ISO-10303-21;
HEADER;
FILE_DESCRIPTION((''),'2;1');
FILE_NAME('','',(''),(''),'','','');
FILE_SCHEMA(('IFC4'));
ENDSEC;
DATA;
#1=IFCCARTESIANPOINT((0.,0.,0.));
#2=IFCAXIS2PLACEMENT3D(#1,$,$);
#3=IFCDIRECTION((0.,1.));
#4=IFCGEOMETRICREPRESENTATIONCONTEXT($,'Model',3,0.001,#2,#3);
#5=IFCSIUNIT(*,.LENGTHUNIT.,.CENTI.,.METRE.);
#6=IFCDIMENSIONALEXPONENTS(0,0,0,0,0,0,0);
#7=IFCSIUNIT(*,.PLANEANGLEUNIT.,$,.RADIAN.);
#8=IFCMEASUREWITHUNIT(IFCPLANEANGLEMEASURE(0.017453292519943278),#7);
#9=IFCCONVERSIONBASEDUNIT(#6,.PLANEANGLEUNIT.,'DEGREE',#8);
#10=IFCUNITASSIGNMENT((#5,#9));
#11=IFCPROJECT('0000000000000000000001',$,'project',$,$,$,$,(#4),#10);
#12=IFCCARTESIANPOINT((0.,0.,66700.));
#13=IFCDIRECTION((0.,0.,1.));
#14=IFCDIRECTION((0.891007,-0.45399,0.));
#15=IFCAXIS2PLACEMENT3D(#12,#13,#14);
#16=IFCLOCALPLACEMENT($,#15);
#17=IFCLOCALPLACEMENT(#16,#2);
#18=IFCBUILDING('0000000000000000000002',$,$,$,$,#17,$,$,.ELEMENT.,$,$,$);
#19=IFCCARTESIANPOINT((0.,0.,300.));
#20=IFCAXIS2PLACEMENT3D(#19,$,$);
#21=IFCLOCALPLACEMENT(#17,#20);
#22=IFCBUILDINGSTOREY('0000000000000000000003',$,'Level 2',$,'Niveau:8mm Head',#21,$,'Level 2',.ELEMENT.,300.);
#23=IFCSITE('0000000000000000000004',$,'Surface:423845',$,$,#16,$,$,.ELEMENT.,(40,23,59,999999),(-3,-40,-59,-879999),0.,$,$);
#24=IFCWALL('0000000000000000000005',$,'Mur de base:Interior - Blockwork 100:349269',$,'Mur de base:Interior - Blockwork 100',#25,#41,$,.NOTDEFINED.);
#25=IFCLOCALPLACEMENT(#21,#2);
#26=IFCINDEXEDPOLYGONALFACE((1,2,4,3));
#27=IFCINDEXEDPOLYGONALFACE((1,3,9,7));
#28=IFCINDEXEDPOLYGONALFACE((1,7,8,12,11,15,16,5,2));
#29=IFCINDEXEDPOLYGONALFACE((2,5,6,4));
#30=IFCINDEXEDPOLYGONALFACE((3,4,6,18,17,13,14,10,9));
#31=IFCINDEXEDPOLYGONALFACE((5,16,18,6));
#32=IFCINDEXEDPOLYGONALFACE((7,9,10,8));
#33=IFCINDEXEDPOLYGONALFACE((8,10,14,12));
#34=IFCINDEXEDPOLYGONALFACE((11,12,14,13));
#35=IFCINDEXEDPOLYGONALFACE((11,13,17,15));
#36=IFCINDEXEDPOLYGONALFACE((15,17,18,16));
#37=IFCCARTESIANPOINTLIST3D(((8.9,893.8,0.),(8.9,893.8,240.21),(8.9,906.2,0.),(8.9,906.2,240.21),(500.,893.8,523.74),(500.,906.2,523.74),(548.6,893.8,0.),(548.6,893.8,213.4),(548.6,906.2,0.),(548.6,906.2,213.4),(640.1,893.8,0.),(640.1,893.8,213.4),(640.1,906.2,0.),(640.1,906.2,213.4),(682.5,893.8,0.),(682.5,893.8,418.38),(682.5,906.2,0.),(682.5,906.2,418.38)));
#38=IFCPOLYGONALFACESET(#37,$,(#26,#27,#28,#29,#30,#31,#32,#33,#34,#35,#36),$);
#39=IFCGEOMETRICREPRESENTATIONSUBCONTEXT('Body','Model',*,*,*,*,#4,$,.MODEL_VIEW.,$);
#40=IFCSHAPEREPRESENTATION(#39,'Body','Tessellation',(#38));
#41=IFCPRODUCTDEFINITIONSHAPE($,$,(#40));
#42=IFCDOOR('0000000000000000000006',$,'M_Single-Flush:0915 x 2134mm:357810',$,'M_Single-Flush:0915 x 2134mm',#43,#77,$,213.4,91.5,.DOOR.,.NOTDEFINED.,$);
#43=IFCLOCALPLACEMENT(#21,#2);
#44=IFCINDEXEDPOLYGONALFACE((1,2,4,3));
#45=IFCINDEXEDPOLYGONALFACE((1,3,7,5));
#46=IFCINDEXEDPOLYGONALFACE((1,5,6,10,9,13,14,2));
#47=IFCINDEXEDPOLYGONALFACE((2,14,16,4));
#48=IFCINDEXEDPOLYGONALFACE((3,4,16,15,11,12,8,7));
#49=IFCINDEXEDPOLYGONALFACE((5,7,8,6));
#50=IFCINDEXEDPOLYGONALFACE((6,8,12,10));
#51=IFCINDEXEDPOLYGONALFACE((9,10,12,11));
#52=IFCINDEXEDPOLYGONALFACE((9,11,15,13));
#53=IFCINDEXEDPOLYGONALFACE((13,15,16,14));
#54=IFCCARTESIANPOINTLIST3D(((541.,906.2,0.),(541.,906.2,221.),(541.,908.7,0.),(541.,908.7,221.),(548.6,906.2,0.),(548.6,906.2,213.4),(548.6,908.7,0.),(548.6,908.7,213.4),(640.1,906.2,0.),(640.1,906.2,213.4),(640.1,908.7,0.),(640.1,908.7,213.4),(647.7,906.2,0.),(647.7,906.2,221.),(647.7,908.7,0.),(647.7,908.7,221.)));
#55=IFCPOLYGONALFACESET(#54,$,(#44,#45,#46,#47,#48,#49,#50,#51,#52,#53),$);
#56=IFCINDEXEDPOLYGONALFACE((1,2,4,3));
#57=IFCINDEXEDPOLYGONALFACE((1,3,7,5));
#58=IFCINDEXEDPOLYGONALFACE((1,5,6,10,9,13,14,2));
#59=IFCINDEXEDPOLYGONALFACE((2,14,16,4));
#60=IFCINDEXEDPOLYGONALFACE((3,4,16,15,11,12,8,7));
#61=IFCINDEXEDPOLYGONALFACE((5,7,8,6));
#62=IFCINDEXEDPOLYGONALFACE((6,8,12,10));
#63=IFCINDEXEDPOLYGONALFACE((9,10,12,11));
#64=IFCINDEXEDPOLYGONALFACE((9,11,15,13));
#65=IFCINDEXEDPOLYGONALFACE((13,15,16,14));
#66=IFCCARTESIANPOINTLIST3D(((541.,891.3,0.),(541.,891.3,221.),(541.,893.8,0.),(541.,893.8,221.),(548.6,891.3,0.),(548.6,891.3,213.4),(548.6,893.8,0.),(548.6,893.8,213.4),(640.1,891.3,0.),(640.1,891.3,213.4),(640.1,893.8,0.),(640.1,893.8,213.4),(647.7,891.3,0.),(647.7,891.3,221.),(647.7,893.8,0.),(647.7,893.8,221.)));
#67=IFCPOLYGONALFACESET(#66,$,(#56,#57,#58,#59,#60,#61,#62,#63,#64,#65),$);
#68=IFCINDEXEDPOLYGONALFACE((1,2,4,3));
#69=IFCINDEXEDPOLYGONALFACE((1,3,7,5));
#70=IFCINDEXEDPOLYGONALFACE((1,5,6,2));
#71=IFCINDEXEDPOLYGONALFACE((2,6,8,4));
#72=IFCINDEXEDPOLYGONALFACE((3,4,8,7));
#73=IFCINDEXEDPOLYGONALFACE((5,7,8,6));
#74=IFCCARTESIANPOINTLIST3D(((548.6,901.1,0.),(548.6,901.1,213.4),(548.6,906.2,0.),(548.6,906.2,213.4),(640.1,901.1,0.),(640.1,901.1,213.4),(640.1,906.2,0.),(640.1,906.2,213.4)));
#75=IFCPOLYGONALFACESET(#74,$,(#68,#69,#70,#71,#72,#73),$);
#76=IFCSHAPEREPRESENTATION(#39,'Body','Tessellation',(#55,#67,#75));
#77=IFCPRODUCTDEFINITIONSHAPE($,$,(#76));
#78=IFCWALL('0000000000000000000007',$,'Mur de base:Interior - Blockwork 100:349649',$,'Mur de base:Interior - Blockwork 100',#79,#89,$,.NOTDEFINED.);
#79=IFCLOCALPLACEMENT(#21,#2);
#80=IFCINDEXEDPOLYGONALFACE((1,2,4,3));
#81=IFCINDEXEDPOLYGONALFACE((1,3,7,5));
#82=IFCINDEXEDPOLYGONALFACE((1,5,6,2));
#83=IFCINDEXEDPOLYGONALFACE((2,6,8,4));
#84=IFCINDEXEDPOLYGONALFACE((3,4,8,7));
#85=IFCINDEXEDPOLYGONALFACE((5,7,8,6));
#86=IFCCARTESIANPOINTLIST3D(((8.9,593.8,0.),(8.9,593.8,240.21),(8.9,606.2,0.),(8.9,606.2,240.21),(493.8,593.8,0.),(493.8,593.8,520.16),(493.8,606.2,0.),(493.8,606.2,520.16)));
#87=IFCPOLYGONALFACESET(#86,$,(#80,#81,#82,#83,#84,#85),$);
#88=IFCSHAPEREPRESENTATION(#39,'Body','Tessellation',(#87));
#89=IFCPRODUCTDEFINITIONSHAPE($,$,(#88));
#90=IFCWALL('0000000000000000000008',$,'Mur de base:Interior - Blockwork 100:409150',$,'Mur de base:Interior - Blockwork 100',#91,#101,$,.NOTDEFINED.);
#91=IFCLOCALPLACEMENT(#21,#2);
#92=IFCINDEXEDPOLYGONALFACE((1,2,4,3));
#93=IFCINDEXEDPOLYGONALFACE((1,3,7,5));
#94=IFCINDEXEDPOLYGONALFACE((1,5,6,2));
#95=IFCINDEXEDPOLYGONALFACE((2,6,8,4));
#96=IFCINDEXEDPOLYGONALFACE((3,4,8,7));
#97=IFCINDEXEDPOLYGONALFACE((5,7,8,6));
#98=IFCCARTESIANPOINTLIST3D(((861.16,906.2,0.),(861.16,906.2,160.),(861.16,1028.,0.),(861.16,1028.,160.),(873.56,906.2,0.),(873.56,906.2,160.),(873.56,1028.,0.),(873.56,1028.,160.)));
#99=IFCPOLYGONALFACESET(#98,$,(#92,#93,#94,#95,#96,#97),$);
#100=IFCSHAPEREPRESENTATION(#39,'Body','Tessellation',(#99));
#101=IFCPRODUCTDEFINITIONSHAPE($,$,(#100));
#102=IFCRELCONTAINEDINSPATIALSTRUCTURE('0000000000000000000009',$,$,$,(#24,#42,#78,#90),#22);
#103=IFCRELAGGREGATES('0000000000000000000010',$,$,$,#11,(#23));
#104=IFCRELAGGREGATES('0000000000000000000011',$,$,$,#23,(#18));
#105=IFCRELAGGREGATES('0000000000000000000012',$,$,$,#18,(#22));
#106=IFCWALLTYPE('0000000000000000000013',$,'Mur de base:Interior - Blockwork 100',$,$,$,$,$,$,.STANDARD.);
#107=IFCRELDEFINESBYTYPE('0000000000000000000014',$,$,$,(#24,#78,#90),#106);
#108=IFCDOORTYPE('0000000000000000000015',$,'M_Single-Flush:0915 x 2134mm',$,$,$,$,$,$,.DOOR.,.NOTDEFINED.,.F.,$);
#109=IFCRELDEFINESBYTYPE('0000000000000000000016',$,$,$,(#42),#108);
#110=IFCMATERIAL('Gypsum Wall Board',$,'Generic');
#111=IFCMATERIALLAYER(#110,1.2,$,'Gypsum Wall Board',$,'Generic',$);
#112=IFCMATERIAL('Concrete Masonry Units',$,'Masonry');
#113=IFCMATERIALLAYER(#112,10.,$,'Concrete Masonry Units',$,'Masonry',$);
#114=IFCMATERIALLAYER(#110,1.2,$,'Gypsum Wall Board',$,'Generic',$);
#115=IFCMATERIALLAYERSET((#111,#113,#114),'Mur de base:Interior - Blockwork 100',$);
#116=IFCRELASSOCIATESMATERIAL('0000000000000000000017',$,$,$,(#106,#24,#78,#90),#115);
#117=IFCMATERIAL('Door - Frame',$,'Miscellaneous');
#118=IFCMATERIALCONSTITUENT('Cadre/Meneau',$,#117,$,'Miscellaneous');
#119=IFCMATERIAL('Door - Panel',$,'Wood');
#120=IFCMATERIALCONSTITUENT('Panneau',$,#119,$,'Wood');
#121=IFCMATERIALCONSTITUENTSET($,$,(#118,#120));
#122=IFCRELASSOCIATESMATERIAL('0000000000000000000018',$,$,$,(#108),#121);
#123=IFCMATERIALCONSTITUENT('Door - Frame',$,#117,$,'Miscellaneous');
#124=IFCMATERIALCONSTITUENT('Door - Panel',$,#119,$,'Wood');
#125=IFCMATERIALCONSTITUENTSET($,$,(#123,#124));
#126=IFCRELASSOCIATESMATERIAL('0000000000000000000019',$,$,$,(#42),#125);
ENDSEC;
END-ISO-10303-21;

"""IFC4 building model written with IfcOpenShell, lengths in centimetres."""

from ifc_helpers import new_model, entity, si_unit, converted_unit, direction, frame, frame_2d, origin, origin_2d_with_axis, place, context, subcontext, project, spatial, polyline, rectangle, outline, extrude, clip, bounded_halfspace, source, transform, mapped, material, layer, layer_set, layer_usage, constituent, constituent_set, type_object, type_shapes, element, fill, save


model = new_model("IFC4")

# Units and contexts
model_context = context("Model", 3, precision=0.001, world=origin(), true_north=direction((0.0, 1.0)))
body_context = subcontext(model_context, "Body", "Model", "MODEL_VIEW")
ifc_project = project(units=[si_unit("LENGTHUNIT", "METRE", prefix="CENTI"), converted_unit("PLANEANGLEUNIT", "DEGREE", entity("IfcPlaneAngleMeasure", 0.017453292519943278), si_unit("PLANEANGLEUNIT", "RADIAN"), dimensions=[0, 0, 0, 0, 0, 0, 0])], contexts=[model_context])

# Site, building, storey
site_placement = place(None, frame((0.0, 0.0, 66700.0), z_axis=(0.0, 0.0, 1.0), x_axis=(0.891007, -0.45399, 0.0)))
site = spatial("IfcSite", under=ifc_project, at=site_placement, Name="Surface:423845", CompositionType="ELEMENT", RefLatitude=(40, 23, 59, 999999), RefLongitude=(-3, -40, -59, -879999), RefElevation=0.0)
building_placement = place(site_placement, origin())
building = spatial("IfcBuilding", under=site, at=building_placement, CompositionType="ELEMENT")
storey_placement = place(building_placement, frame((0.0, 0.0, 300.0)))
storey = spatial("IfcBuildingStorey", under=building, at=storey_placement, Name="Level 2", ObjectType="Niveau:8mm Head", LongName="Level 2", CompositionType="ELEMENT", Elevation=300.0)

# Shared definitions
ifc_material_1 = material(Name="Gypsum Wall Board", Category="Generic")
ifc_layer_1 = layer(ifc_material_1, 1.2, Name="Gypsum Wall Board", Category="Generic")
ifc_material_2 = material(Name="Concrete Masonry Units", Category="Masonry")
ifc_layer_2 = layer(ifc_material_2, 10.0, Name="Concrete Masonry Units", Category="Masonry")
ifc_layer_3 = layer(ifc_material_1, 1.2, Name="Gypsum Wall Board", Category="Generic")
ifc_layer_set_1 = layer_set([ifc_layer_1, ifc_layer_2, ifc_layer_3], Name="Mur de base:Interior - Blockwork 100")
wall_type = type_object("IfcWallType", Name="Mur de base:Interior - Blockwork 100", PredefinedType="STANDARD", material=ifc_layer_set_1)

# Shared definitions
ifc_material_3 = material(Name="Door - Frame", Category="Miscellaneous")
ifc_material_4 = material(Name="Door - Panel", Category="Wood")

# Wall, opening, door
ifc_layer_usage_1 = layer_usage(ifc_layer_set_1, "AXIS2", "NEGATIVE", 6.2)
wall_1_placement = place(storey_placement, frame((682.5, 900.0, 0.0), z_axis=(0.0, 0.0, 1.0), x_axis=(-1.0, 0.0, 0.0)))
wall_1 = element("IfcWall", 1, at=wall_1_placement, inside=storey, type_object=wall_type, material=ifc_layer_usage_1, Name="Mur de base:Interior - Blockwork 100:349269", ObjectType="Mur de base:Interior - Blockwork 100", PredefinedType="NOTDEFINED", context=body_context, shape_type="Clipping", body=[
    clip(clip(extrude(rectangle(XDim=673.6, YDim=12.4, at=frame_2d((336.8, 0.0), x_axis=(-1.0, 0.0))), origin(), (0.0, 0.0, 1.0), 523.74), bounded_halfspace(frame((182.5, -6.2, 523.74), z_axis=(0.5, 0.0, 0.866025), x_axis=(0.0, 1.0, 0.0)), False, frame((182.5, -6.2, 523.74)), polyline([(0.0, 0.0), (491.1, 0.0), (491.1, 12.4), (6.2, 12.4), (0.0, 12.4), (0.0, 0.0)]))), bounded_halfspace(frame((0.0, -6.2, 418.38), z_axis=(-0.5, 0.0, 0.866025), x_axis=(0.0, -1.0, 0.0)), False, frame((0.0, -6.2, 418.38)), polyline([(0.0, 0.0), (182.5, 0.0), (182.5, 12.4), (176.3, 12.4), (0.0, 12.4), (0.0, 0.0)]))),
])
opening_1_placement = place(wall_1_placement, frame((133.9, 6.2, 0.0)))
opening_1 = element("IfcOpeningElement", 2, at=opening_1_placement, cuts=wall_1, PredefinedType="OPENING", context=body_context, shape_type="SweptSolid", body=[
    extrude(rectangle(XDim=91.5, YDim=213.4, at=frame_2d((106.7, 45.75), x_axis=(0.0, 1.0))), frame((0.0, 0.0, 0.0), z_axis=(0.0, -1.0, 0.0), x_axis=(0.0, 0.0, 1.0)), (0.0, 0.0, 1.0), 12.4),
])
ifc_constituent_1 = constituent(ifc_material_3, Name="Door - Frame", Category="Miscellaneous")
ifc_constituent_2 = constituent(ifc_material_4, Name="Door - Panel", Category="Wood")
ifc_constituent_set_1 = constituent_set(constituents=[ifc_constituent_1, ifc_constituent_2])
ifc_constituent_3 = constituent(ifc_material_3, Name="Cadre/Meneau", Category="Miscellaneous")
ifc_constituent_4 = constituent(ifc_material_4, Name="Panneau", Category="Wood")
ifc_constituent_set_2 = constituent_set(constituents=[ifc_constituent_3, ifc_constituent_4])
door_type_1 = type_object("IfcDoorType", Name="M_Single-Flush:0915 x 2134mm", OperationType="NOTDEFINED", ParameterTakesPrecedence=False, PredefinedType="DOOR", material=ifc_constituent_set_2)
shared_shape_1 = source(origin(), body_context, "Body", "SweptSolid", [
    extrude(outline(polyline([(-53.35, -112.4), (53.35, -112.4), (53.35, 108.6), (45.75, 108.6), (45.75, -104.8), (-45.75, -104.8), (-45.75, 108.6), (-53.35, 108.6), (-53.35, -112.4)])), frame((45.75, 12.4, 108.6), z_axis=(0.0, 1.0, 0.0), x_axis=(1.0, 0.0, 0.0)), (0.0, 0.0, 1.0), 2.5),
    extrude(outline(polyline([(-112.4, -53.35), (108.6, -53.35), (108.6, -45.75), (-104.8, -45.75), (-104.8, 45.75), (108.6, 45.75), (108.6, 53.35), (-112.4, 53.35), (-112.4, -53.35)])), frame((45.75, -2.5, 108.6), z_axis=(0.0, 1.0, 0.0), x_axis=(0.0, 0.0, -1.0)), (0.0, 0.0, 1.0), 2.5),
    extrude(rectangle(XDim=5.1, YDim=91.5, at=origin_2d_with_axis()), frame((45.75, 9.85, 0.0), z_axis=(0.0, 0.0, 1.0), x_axis=(0.0, 1.0, 0.0)), (0.0, 0.0, 1.0), 213.4),
])
type_shapes(door_type_1, [shared_shape_1])
door_1_placement = place(opening_1_placement, frame((0.0, 0.0, 0.0), z_axis=(0.0, 0.0, 1.0), x_axis=(-1.0, 0.0, 0.0)))
door_1 = element("IfcDoor", 3, at=door_1_placement, inside=storey, type_object=door_type_1, material=ifc_constituent_set_1, Name="M_Single-Flush:0915 x 2134mm:357810", ObjectType="M_Single-Flush:0915 x 2134mm", OperationType="NOTDEFINED", OverallHeight=213.4, OverallWidth=91.5, PredefinedType="DOOR", context=body_context, shape_type="MappedRepresentation", body=[
    mapped(shared_shape_1, transform((0.0, 0.0, 0.0), scale=1.0)),
])
fill(opening_1, door_1)

# Walls
ifc_layer_usage_2 = layer_usage(ifc_layer_set_1, "AXIS2", "NEGATIVE", 6.2)
wall_2_placement = place(storey_placement, frame((493.8, 600.0, 0.0), z_axis=(0.0, 0.0, 1.0), x_axis=(-1.0, 0.0, 0.0)))
element("IfcWall", 4, at=wall_2_placement, inside=storey, type_object=wall_type, material=ifc_layer_usage_2, Name="Mur de base:Interior - Blockwork 100:349649", ObjectType="Mur de base:Interior - Blockwork 100", PredefinedType="NOTDEFINED", context=body_context, shape_type="Clipping", body=[
    clip(extrude(rectangle(XDim=484.9, YDim=12.4, at=frame_2d((242.45, 0.0), x_axis=(-1.0, 0.0))), origin(), (0.0, 0.0, 1.0), 520.16), bounded_halfspace(frame((0.0, -6.2, 520.16), z_axis=(0.5, 0.0, 0.866025), x_axis=(0.0, 1.0, 0.0)), False, frame((0.0, -6.2, 520.16)), polyline([(0.0, 0.0), (484.9, 0.0), (484.9, 12.4), (0.0, 12.4), (0.0, 0.0)]))),
])
ifc_layer_usage_3 = layer_usage(ifc_layer_set_1, "AXIS2", "NEGATIVE", 6.2)
wall_3_placement = place(storey_placement, frame((867.36, 1028.0, 0.0), z_axis=(0.0, 0.0, 1.0), x_axis=(0.0, -1.0, 0.0)))
element("IfcWall", 5, at=wall_3_placement, inside=storey, type_object=wall_type, material=ifc_layer_usage_3, Name="Mur de base:Interior - Blockwork 100:409150", ObjectType="Mur de base:Interior - Blockwork 100", PredefinedType="NOTDEFINED", context=body_context, shape_type="SweptSolid", body=[
    extrude(rectangle(XDim=121.8, YDim=12.4, at=frame_2d((60.9, 0.0), x_axis=(-1.0, 0.0))), origin(), (0.0, 0.0, 1.0), 160.0),
])

save(model, "model.ifc")
